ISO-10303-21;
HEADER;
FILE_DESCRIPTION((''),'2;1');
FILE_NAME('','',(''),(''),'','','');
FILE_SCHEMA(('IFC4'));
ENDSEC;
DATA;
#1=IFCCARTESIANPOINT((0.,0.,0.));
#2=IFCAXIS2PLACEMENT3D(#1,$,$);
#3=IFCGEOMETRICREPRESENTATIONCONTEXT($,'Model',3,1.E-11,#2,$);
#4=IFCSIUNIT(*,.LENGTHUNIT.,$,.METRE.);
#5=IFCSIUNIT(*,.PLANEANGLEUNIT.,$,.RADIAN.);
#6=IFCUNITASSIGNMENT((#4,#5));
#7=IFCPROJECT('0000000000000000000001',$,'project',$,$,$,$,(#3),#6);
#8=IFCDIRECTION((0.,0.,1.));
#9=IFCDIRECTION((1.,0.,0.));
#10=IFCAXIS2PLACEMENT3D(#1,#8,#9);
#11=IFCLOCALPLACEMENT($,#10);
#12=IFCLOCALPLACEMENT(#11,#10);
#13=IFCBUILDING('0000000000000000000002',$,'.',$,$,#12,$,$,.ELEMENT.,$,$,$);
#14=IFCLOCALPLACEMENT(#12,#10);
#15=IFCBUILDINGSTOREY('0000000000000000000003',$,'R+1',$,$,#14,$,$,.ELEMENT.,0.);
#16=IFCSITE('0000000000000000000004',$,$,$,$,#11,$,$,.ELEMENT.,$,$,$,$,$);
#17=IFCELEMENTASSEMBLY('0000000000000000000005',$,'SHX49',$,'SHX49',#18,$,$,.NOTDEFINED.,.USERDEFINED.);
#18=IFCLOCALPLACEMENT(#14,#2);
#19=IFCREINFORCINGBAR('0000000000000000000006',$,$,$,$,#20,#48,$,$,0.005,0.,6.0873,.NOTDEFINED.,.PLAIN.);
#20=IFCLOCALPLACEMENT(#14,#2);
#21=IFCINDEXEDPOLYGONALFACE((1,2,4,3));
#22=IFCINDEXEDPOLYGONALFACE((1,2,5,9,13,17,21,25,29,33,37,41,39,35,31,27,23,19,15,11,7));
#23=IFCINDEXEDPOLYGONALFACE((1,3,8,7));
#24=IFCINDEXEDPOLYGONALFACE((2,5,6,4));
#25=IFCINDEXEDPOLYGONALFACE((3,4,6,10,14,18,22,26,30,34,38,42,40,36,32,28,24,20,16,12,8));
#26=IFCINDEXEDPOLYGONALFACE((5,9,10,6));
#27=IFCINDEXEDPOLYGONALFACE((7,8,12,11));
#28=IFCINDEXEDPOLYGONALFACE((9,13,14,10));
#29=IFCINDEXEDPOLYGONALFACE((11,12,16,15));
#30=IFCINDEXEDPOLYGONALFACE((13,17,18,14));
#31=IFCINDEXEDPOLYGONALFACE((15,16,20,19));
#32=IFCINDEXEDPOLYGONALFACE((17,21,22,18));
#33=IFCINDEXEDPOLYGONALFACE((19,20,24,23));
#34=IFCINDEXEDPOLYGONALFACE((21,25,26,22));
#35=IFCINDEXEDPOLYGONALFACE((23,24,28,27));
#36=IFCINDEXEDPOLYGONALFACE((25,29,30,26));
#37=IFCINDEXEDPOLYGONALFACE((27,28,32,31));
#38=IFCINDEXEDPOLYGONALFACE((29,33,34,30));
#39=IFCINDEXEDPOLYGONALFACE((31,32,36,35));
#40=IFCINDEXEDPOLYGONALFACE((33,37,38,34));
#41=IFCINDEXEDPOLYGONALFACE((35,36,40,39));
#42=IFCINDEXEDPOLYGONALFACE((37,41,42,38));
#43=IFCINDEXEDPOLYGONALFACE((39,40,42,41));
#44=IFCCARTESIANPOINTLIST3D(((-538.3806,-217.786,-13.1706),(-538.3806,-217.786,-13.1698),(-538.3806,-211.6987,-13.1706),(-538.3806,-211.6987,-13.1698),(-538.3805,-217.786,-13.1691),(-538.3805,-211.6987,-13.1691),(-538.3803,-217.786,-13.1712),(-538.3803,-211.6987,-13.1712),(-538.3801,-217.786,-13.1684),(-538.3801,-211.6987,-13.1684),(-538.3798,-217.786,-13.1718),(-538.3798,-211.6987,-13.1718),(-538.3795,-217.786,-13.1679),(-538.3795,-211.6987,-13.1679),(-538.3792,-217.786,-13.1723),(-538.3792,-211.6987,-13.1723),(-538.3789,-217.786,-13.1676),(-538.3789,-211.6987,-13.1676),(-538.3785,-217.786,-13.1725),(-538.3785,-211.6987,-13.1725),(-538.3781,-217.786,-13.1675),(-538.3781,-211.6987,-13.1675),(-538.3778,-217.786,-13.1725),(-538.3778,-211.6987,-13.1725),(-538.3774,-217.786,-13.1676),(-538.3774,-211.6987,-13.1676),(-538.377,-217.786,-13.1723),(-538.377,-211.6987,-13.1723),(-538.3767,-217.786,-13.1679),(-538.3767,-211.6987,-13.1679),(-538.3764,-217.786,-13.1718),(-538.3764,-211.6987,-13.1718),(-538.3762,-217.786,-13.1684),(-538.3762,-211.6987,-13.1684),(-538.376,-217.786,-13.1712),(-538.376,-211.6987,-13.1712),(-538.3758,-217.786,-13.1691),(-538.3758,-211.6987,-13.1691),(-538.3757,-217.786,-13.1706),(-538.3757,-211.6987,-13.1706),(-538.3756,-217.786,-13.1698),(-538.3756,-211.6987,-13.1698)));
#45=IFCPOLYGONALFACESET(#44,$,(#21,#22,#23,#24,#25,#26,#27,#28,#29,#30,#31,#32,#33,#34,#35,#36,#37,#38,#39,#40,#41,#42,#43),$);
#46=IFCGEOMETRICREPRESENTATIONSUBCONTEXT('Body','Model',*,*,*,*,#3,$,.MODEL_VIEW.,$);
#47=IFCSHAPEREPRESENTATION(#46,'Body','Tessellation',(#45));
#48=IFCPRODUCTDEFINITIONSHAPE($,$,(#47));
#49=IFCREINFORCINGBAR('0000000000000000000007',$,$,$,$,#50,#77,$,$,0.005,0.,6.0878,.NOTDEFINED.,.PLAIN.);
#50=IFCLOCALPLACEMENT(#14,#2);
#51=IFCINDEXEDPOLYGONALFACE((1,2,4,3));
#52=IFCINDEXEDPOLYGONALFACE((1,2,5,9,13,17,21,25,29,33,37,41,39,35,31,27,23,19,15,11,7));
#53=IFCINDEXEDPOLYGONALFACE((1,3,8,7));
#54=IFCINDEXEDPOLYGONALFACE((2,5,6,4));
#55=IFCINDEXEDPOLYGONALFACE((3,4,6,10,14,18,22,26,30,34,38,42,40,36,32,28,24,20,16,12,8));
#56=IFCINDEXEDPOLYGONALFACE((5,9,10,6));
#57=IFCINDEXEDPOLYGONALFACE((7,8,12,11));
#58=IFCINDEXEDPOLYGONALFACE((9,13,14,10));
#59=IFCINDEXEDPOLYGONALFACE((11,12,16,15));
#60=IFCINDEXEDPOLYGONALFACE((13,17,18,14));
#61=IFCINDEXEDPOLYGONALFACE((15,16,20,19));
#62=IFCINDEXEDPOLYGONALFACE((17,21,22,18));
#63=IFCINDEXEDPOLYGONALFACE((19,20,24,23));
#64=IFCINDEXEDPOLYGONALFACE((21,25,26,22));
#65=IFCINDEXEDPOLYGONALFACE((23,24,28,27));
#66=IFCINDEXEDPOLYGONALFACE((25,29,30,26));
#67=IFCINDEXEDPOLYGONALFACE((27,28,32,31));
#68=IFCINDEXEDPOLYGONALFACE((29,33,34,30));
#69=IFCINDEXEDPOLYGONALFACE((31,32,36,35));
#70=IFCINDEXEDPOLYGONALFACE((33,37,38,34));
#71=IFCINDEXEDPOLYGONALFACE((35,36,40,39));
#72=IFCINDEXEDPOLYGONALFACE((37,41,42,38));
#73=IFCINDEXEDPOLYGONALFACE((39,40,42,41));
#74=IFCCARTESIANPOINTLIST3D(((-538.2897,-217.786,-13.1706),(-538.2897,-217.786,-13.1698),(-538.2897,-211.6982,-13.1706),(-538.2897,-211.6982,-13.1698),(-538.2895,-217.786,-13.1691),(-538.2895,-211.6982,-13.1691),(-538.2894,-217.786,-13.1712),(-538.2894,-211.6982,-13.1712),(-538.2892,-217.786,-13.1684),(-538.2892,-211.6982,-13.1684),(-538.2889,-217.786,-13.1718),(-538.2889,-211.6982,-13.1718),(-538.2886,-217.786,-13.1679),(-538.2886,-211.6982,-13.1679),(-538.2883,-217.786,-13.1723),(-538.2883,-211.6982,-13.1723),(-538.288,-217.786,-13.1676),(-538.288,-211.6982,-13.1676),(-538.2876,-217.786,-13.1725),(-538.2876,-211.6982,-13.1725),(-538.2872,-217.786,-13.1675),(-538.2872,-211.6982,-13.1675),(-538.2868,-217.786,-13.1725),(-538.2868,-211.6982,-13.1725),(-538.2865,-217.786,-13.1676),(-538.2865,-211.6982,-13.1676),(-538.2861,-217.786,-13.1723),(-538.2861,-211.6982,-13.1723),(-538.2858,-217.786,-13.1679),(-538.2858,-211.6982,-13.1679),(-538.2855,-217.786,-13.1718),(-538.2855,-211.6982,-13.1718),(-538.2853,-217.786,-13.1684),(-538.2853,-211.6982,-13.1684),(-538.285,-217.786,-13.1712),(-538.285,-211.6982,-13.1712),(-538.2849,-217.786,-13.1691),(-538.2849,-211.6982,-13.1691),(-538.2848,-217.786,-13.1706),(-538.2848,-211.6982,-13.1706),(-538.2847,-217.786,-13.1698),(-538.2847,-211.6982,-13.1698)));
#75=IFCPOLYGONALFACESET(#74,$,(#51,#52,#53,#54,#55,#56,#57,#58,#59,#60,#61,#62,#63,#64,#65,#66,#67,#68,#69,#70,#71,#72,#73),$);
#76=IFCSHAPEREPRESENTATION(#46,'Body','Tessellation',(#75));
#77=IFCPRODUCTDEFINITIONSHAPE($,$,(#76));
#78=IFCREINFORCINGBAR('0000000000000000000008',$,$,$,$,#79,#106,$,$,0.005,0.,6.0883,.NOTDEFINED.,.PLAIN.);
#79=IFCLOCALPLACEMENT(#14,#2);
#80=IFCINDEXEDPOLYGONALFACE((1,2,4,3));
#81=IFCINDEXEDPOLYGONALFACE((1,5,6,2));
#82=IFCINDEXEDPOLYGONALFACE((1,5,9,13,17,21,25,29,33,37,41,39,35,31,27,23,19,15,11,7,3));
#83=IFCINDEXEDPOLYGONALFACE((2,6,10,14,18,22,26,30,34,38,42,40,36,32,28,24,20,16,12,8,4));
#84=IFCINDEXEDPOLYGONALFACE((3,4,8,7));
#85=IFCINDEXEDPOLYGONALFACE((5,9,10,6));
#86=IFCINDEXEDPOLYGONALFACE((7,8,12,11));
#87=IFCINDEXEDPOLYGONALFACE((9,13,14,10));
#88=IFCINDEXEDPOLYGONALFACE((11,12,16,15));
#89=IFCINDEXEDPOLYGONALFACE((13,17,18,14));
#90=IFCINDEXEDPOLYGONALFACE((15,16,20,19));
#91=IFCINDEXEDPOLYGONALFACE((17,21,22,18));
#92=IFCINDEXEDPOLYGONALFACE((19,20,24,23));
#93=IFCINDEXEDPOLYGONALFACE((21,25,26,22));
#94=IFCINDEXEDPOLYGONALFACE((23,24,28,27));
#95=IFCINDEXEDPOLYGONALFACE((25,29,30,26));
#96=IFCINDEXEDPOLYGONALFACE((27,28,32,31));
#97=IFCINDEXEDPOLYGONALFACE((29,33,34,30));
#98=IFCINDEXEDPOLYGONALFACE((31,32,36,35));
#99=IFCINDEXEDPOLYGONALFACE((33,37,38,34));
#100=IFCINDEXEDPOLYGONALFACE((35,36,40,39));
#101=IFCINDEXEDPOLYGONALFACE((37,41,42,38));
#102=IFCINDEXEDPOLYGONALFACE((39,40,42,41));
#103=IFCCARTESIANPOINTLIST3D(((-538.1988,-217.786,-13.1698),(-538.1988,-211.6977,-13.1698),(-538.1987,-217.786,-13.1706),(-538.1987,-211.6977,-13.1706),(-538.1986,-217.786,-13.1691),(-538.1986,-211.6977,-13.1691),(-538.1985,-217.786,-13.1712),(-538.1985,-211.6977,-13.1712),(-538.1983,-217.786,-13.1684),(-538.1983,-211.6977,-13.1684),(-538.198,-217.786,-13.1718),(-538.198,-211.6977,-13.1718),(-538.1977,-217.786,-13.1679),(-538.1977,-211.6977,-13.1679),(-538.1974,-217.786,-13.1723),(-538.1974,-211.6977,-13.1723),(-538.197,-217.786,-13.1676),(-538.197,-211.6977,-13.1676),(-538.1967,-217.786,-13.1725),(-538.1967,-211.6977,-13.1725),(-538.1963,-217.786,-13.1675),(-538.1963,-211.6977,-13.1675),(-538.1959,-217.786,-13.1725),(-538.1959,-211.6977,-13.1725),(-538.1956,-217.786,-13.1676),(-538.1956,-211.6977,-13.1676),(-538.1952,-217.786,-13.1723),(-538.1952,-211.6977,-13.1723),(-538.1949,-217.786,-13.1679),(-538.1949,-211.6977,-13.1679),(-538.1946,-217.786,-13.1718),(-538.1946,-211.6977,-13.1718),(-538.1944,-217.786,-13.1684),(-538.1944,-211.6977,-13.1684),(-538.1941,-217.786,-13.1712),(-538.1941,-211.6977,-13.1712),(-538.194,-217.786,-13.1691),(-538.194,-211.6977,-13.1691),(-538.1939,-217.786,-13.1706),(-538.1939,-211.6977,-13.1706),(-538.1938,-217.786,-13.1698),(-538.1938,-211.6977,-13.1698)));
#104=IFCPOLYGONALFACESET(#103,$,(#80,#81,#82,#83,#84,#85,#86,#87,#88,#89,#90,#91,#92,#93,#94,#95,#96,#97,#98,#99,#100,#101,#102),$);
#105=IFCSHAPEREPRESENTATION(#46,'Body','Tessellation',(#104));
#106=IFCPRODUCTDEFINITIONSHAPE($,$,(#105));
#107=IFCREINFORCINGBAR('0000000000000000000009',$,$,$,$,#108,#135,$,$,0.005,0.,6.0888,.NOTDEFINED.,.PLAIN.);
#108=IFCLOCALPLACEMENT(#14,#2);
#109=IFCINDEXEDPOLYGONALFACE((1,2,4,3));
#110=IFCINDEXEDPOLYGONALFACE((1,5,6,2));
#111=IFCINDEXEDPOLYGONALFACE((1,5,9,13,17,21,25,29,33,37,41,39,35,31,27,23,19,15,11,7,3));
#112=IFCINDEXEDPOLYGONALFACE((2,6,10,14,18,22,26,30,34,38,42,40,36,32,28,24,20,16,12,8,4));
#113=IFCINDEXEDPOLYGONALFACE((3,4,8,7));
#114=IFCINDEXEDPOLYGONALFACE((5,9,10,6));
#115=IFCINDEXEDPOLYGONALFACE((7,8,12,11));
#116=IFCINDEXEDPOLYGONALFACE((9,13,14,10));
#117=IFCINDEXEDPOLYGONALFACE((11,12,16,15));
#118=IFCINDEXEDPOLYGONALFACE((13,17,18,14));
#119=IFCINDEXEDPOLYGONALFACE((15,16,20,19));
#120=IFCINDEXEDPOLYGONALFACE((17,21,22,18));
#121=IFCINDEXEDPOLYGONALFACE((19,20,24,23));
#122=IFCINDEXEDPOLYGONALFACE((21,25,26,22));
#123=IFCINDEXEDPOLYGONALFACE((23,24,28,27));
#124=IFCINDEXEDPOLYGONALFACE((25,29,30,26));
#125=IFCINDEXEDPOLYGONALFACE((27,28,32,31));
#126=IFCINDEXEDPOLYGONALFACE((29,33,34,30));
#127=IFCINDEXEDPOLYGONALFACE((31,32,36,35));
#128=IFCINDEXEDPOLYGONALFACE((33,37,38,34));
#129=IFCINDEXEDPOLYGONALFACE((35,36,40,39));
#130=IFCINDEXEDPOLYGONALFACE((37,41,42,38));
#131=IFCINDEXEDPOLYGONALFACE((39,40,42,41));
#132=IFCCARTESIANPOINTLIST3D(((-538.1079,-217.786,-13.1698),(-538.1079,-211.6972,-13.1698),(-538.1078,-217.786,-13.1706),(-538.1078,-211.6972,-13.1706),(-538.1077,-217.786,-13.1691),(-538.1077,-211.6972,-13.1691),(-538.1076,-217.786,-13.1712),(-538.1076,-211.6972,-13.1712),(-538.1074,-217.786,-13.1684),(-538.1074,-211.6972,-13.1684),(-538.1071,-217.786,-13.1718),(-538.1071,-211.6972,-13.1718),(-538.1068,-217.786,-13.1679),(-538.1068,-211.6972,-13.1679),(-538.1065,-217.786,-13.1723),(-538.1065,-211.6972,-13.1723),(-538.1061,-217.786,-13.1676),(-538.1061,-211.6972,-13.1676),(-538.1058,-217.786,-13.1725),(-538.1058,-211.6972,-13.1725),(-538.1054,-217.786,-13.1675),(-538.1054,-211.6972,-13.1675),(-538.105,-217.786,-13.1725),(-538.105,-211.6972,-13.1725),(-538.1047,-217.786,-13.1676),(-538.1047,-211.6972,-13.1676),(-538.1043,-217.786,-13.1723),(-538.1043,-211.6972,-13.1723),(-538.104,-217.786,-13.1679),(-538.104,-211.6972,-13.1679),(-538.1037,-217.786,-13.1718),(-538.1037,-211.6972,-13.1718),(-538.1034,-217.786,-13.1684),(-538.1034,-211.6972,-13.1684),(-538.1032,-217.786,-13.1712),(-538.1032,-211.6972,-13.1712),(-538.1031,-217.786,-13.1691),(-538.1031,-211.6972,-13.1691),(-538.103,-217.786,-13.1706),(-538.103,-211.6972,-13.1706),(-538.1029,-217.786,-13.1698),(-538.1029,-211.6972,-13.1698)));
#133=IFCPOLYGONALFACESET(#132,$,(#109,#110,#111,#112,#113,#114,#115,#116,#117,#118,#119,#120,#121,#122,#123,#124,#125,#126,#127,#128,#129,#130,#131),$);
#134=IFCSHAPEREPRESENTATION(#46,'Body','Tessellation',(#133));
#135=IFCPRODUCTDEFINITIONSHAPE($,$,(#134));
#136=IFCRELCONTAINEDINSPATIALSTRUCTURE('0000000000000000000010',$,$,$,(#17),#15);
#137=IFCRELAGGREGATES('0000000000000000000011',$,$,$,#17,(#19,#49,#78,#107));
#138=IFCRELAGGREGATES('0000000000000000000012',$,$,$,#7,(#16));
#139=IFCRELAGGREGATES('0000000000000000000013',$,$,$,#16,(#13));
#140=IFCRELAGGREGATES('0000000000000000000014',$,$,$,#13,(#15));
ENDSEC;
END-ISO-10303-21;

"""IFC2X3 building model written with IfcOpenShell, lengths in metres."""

from ifc_helpers import new_model, entity, si_unit, origin, origin_with_axes, place, context, subcontext, project, spatial, shape, element, aggregate, save


model = new_model("IFC2X3")

# Units and contexts
model_context = context("Model", 3, precision=1e-11, world=origin())
body_context = subcontext(model_context, "Body", "Model", "MODEL_VIEW")
ifc_project = project(units=[si_unit("LENGTHUNIT", "METRE"), si_unit("PLANEANGLEUNIT", "RADIAN")], contexts=[model_context])

# Site, building, storey
site_placement = place(None, origin_with_axes())
site = spatial("IfcSite", under=ifc_project, at=site_placement, CompositionType="ELEMENT")
building_placement = place(site_placement, origin_with_axes())
building = spatial("IfcBuilding", under=site, at=building_placement, Name=".", CompositionType="ELEMENT")
storey_placement = place(building_placement, origin_with_axes())
storey = spatial("IfcBuildingStorey", under=building, at=storey_placement, Name="R+1", CompositionType="ELEMENT", Elevation=0.0)

# Element assembly, reinforcing bars
assembly_1_placement = place(storey_placement, origin_with_axes())
assembly_1 = element("IfcElementAssembly", 1, at=assembly_1_placement, inside=storey, Name="SHX49", ObjectType="SHX49", AssemblyPlace="NOTDEFINED", PredefinedType="USERDEFINED")
reinforcing_bar_1_placement = place(assembly_1_placement, origin_with_axes())
reinforcing_bar_1 = element("IfcReinforcingBar", 2, at=reinforcing_bar_1_placement, BarLength=6.0873, BarRole="NOTDEFINED", BarSurface="PLAIN", CrossSectionArea=0.0, NominalDiameter=0.005, shapes=[
    shape(body_context, "Body", "AdvancedSweptSolid", [entity("IfcSweptDiskSolid", entity("IfcPolyline", [entity("IfcCartesianPoint", [538.3781, 211.6987, 13.17]), entity("IfcCartesianPoint", [538.3781, 217.786, 13.17])]), 0.0025, None, 0.0, 6.0873)]),
    shape(body_context, "Body", "AdvancedSweptSolid", [entity("IfcSweptDiskSolid", entity("IfcPolyline", [entity("IfcCartesianPoint", [538.3781, 211.6987, 13.17]), entity("IfcCartesianPoint", [538.3781, 217.786, 13.17])]), 0.0025, None, 0.0, 6.0873)]),
])
reinforcing_bar_2_placement = place(assembly_1_placement, origin_with_axes())
reinforcing_bar_2 = element("IfcReinforcingBar", 3, at=reinforcing_bar_2_placement, BarLength=6.0878, BarRole="NOTDEFINED", BarSurface="PLAIN", CrossSectionArea=0.0, NominalDiameter=0.005, shapes=[
    shape(body_context, "Body", "AdvancedSweptSolid", [entity("IfcSweptDiskSolid", entity("IfcPolyline", [entity("IfcCartesianPoint", [538.2872, 211.6982, 13.17]), entity("IfcCartesianPoint", [538.2872, 217.786, 13.17])]), 0.0025, None, 0.0, 6.0878)]),
    shape(body_context, "Body", "AdvancedSweptSolid", [entity("IfcSweptDiskSolid", entity("IfcPolyline", [entity("IfcCartesianPoint", [538.2872, 211.6982, 13.17]), entity("IfcCartesianPoint", [538.2872, 217.786, 13.17])]), 0.0025, None, 0.0, 6.0878)]),
])
reinforcing_bar_3_placement = place(assembly_1_placement, origin_with_axes())
reinforcing_bar_3 = element("IfcReinforcingBar", 4, at=reinforcing_bar_3_placement, BarLength=6.0883, BarRole="NOTDEFINED", BarSurface="PLAIN", CrossSectionArea=0.0, NominalDiameter=0.005, shapes=[
    shape(body_context, "Body", "AdvancedSweptSolid", [entity("IfcSweptDiskSolid", entity("IfcPolyline", [entity("IfcCartesianPoint", [538.1963, 211.6977, 13.17]), entity("IfcCartesianPoint", [538.1963, 217.786, 13.17])]), 0.0025, None, 0.0, 6.0883)]),
    shape(body_context, "Body", "AdvancedSweptSolid", [entity("IfcSweptDiskSolid", entity("IfcPolyline", [entity("IfcCartesianPoint", [538.1963, 211.6977, 13.17]), entity("IfcCartesianPoint", [538.1963, 217.786, 13.17])]), 0.0025, None, 0.0, 6.0883)]),
])
reinforcing_bar_4_placement = place(assembly_1_placement, origin_with_axes())
reinforcing_bar_4 = element("IfcReinforcingBar", 5, at=reinforcing_bar_4_placement, BarLength=6.0888, BarRole="NOTDEFINED", BarSurface="PLAIN", CrossSectionArea=0.0, NominalDiameter=0.005, shapes=[
    shape(body_context, "Body", "AdvancedSweptSolid", [entity("IfcSweptDiskSolid", entity("IfcPolyline", [entity("IfcCartesianPoint", [538.1054, 211.6972, 13.17]), entity("IfcCartesianPoint", [538.1054, 217.786, 13.17])]), 0.0025, None, 0.0, 6.0888)]),
    shape(body_context, "Body", "AdvancedSweptSolid", [entity("IfcSweptDiskSolid", entity("IfcPolyline", [entity("IfcCartesianPoint", [538.1054, 211.6972, 13.17]), entity("IfcCartesianPoint", [538.1054, 217.786, 13.17])]), 0.0025, None, 0.0, 6.0888)]),
])
aggregate(assembly_1, [reinforcing_bar_1, reinforcing_bar_2, reinforcing_bar_3, reinforcing_bar_4])

save(model, "model.ifc")
